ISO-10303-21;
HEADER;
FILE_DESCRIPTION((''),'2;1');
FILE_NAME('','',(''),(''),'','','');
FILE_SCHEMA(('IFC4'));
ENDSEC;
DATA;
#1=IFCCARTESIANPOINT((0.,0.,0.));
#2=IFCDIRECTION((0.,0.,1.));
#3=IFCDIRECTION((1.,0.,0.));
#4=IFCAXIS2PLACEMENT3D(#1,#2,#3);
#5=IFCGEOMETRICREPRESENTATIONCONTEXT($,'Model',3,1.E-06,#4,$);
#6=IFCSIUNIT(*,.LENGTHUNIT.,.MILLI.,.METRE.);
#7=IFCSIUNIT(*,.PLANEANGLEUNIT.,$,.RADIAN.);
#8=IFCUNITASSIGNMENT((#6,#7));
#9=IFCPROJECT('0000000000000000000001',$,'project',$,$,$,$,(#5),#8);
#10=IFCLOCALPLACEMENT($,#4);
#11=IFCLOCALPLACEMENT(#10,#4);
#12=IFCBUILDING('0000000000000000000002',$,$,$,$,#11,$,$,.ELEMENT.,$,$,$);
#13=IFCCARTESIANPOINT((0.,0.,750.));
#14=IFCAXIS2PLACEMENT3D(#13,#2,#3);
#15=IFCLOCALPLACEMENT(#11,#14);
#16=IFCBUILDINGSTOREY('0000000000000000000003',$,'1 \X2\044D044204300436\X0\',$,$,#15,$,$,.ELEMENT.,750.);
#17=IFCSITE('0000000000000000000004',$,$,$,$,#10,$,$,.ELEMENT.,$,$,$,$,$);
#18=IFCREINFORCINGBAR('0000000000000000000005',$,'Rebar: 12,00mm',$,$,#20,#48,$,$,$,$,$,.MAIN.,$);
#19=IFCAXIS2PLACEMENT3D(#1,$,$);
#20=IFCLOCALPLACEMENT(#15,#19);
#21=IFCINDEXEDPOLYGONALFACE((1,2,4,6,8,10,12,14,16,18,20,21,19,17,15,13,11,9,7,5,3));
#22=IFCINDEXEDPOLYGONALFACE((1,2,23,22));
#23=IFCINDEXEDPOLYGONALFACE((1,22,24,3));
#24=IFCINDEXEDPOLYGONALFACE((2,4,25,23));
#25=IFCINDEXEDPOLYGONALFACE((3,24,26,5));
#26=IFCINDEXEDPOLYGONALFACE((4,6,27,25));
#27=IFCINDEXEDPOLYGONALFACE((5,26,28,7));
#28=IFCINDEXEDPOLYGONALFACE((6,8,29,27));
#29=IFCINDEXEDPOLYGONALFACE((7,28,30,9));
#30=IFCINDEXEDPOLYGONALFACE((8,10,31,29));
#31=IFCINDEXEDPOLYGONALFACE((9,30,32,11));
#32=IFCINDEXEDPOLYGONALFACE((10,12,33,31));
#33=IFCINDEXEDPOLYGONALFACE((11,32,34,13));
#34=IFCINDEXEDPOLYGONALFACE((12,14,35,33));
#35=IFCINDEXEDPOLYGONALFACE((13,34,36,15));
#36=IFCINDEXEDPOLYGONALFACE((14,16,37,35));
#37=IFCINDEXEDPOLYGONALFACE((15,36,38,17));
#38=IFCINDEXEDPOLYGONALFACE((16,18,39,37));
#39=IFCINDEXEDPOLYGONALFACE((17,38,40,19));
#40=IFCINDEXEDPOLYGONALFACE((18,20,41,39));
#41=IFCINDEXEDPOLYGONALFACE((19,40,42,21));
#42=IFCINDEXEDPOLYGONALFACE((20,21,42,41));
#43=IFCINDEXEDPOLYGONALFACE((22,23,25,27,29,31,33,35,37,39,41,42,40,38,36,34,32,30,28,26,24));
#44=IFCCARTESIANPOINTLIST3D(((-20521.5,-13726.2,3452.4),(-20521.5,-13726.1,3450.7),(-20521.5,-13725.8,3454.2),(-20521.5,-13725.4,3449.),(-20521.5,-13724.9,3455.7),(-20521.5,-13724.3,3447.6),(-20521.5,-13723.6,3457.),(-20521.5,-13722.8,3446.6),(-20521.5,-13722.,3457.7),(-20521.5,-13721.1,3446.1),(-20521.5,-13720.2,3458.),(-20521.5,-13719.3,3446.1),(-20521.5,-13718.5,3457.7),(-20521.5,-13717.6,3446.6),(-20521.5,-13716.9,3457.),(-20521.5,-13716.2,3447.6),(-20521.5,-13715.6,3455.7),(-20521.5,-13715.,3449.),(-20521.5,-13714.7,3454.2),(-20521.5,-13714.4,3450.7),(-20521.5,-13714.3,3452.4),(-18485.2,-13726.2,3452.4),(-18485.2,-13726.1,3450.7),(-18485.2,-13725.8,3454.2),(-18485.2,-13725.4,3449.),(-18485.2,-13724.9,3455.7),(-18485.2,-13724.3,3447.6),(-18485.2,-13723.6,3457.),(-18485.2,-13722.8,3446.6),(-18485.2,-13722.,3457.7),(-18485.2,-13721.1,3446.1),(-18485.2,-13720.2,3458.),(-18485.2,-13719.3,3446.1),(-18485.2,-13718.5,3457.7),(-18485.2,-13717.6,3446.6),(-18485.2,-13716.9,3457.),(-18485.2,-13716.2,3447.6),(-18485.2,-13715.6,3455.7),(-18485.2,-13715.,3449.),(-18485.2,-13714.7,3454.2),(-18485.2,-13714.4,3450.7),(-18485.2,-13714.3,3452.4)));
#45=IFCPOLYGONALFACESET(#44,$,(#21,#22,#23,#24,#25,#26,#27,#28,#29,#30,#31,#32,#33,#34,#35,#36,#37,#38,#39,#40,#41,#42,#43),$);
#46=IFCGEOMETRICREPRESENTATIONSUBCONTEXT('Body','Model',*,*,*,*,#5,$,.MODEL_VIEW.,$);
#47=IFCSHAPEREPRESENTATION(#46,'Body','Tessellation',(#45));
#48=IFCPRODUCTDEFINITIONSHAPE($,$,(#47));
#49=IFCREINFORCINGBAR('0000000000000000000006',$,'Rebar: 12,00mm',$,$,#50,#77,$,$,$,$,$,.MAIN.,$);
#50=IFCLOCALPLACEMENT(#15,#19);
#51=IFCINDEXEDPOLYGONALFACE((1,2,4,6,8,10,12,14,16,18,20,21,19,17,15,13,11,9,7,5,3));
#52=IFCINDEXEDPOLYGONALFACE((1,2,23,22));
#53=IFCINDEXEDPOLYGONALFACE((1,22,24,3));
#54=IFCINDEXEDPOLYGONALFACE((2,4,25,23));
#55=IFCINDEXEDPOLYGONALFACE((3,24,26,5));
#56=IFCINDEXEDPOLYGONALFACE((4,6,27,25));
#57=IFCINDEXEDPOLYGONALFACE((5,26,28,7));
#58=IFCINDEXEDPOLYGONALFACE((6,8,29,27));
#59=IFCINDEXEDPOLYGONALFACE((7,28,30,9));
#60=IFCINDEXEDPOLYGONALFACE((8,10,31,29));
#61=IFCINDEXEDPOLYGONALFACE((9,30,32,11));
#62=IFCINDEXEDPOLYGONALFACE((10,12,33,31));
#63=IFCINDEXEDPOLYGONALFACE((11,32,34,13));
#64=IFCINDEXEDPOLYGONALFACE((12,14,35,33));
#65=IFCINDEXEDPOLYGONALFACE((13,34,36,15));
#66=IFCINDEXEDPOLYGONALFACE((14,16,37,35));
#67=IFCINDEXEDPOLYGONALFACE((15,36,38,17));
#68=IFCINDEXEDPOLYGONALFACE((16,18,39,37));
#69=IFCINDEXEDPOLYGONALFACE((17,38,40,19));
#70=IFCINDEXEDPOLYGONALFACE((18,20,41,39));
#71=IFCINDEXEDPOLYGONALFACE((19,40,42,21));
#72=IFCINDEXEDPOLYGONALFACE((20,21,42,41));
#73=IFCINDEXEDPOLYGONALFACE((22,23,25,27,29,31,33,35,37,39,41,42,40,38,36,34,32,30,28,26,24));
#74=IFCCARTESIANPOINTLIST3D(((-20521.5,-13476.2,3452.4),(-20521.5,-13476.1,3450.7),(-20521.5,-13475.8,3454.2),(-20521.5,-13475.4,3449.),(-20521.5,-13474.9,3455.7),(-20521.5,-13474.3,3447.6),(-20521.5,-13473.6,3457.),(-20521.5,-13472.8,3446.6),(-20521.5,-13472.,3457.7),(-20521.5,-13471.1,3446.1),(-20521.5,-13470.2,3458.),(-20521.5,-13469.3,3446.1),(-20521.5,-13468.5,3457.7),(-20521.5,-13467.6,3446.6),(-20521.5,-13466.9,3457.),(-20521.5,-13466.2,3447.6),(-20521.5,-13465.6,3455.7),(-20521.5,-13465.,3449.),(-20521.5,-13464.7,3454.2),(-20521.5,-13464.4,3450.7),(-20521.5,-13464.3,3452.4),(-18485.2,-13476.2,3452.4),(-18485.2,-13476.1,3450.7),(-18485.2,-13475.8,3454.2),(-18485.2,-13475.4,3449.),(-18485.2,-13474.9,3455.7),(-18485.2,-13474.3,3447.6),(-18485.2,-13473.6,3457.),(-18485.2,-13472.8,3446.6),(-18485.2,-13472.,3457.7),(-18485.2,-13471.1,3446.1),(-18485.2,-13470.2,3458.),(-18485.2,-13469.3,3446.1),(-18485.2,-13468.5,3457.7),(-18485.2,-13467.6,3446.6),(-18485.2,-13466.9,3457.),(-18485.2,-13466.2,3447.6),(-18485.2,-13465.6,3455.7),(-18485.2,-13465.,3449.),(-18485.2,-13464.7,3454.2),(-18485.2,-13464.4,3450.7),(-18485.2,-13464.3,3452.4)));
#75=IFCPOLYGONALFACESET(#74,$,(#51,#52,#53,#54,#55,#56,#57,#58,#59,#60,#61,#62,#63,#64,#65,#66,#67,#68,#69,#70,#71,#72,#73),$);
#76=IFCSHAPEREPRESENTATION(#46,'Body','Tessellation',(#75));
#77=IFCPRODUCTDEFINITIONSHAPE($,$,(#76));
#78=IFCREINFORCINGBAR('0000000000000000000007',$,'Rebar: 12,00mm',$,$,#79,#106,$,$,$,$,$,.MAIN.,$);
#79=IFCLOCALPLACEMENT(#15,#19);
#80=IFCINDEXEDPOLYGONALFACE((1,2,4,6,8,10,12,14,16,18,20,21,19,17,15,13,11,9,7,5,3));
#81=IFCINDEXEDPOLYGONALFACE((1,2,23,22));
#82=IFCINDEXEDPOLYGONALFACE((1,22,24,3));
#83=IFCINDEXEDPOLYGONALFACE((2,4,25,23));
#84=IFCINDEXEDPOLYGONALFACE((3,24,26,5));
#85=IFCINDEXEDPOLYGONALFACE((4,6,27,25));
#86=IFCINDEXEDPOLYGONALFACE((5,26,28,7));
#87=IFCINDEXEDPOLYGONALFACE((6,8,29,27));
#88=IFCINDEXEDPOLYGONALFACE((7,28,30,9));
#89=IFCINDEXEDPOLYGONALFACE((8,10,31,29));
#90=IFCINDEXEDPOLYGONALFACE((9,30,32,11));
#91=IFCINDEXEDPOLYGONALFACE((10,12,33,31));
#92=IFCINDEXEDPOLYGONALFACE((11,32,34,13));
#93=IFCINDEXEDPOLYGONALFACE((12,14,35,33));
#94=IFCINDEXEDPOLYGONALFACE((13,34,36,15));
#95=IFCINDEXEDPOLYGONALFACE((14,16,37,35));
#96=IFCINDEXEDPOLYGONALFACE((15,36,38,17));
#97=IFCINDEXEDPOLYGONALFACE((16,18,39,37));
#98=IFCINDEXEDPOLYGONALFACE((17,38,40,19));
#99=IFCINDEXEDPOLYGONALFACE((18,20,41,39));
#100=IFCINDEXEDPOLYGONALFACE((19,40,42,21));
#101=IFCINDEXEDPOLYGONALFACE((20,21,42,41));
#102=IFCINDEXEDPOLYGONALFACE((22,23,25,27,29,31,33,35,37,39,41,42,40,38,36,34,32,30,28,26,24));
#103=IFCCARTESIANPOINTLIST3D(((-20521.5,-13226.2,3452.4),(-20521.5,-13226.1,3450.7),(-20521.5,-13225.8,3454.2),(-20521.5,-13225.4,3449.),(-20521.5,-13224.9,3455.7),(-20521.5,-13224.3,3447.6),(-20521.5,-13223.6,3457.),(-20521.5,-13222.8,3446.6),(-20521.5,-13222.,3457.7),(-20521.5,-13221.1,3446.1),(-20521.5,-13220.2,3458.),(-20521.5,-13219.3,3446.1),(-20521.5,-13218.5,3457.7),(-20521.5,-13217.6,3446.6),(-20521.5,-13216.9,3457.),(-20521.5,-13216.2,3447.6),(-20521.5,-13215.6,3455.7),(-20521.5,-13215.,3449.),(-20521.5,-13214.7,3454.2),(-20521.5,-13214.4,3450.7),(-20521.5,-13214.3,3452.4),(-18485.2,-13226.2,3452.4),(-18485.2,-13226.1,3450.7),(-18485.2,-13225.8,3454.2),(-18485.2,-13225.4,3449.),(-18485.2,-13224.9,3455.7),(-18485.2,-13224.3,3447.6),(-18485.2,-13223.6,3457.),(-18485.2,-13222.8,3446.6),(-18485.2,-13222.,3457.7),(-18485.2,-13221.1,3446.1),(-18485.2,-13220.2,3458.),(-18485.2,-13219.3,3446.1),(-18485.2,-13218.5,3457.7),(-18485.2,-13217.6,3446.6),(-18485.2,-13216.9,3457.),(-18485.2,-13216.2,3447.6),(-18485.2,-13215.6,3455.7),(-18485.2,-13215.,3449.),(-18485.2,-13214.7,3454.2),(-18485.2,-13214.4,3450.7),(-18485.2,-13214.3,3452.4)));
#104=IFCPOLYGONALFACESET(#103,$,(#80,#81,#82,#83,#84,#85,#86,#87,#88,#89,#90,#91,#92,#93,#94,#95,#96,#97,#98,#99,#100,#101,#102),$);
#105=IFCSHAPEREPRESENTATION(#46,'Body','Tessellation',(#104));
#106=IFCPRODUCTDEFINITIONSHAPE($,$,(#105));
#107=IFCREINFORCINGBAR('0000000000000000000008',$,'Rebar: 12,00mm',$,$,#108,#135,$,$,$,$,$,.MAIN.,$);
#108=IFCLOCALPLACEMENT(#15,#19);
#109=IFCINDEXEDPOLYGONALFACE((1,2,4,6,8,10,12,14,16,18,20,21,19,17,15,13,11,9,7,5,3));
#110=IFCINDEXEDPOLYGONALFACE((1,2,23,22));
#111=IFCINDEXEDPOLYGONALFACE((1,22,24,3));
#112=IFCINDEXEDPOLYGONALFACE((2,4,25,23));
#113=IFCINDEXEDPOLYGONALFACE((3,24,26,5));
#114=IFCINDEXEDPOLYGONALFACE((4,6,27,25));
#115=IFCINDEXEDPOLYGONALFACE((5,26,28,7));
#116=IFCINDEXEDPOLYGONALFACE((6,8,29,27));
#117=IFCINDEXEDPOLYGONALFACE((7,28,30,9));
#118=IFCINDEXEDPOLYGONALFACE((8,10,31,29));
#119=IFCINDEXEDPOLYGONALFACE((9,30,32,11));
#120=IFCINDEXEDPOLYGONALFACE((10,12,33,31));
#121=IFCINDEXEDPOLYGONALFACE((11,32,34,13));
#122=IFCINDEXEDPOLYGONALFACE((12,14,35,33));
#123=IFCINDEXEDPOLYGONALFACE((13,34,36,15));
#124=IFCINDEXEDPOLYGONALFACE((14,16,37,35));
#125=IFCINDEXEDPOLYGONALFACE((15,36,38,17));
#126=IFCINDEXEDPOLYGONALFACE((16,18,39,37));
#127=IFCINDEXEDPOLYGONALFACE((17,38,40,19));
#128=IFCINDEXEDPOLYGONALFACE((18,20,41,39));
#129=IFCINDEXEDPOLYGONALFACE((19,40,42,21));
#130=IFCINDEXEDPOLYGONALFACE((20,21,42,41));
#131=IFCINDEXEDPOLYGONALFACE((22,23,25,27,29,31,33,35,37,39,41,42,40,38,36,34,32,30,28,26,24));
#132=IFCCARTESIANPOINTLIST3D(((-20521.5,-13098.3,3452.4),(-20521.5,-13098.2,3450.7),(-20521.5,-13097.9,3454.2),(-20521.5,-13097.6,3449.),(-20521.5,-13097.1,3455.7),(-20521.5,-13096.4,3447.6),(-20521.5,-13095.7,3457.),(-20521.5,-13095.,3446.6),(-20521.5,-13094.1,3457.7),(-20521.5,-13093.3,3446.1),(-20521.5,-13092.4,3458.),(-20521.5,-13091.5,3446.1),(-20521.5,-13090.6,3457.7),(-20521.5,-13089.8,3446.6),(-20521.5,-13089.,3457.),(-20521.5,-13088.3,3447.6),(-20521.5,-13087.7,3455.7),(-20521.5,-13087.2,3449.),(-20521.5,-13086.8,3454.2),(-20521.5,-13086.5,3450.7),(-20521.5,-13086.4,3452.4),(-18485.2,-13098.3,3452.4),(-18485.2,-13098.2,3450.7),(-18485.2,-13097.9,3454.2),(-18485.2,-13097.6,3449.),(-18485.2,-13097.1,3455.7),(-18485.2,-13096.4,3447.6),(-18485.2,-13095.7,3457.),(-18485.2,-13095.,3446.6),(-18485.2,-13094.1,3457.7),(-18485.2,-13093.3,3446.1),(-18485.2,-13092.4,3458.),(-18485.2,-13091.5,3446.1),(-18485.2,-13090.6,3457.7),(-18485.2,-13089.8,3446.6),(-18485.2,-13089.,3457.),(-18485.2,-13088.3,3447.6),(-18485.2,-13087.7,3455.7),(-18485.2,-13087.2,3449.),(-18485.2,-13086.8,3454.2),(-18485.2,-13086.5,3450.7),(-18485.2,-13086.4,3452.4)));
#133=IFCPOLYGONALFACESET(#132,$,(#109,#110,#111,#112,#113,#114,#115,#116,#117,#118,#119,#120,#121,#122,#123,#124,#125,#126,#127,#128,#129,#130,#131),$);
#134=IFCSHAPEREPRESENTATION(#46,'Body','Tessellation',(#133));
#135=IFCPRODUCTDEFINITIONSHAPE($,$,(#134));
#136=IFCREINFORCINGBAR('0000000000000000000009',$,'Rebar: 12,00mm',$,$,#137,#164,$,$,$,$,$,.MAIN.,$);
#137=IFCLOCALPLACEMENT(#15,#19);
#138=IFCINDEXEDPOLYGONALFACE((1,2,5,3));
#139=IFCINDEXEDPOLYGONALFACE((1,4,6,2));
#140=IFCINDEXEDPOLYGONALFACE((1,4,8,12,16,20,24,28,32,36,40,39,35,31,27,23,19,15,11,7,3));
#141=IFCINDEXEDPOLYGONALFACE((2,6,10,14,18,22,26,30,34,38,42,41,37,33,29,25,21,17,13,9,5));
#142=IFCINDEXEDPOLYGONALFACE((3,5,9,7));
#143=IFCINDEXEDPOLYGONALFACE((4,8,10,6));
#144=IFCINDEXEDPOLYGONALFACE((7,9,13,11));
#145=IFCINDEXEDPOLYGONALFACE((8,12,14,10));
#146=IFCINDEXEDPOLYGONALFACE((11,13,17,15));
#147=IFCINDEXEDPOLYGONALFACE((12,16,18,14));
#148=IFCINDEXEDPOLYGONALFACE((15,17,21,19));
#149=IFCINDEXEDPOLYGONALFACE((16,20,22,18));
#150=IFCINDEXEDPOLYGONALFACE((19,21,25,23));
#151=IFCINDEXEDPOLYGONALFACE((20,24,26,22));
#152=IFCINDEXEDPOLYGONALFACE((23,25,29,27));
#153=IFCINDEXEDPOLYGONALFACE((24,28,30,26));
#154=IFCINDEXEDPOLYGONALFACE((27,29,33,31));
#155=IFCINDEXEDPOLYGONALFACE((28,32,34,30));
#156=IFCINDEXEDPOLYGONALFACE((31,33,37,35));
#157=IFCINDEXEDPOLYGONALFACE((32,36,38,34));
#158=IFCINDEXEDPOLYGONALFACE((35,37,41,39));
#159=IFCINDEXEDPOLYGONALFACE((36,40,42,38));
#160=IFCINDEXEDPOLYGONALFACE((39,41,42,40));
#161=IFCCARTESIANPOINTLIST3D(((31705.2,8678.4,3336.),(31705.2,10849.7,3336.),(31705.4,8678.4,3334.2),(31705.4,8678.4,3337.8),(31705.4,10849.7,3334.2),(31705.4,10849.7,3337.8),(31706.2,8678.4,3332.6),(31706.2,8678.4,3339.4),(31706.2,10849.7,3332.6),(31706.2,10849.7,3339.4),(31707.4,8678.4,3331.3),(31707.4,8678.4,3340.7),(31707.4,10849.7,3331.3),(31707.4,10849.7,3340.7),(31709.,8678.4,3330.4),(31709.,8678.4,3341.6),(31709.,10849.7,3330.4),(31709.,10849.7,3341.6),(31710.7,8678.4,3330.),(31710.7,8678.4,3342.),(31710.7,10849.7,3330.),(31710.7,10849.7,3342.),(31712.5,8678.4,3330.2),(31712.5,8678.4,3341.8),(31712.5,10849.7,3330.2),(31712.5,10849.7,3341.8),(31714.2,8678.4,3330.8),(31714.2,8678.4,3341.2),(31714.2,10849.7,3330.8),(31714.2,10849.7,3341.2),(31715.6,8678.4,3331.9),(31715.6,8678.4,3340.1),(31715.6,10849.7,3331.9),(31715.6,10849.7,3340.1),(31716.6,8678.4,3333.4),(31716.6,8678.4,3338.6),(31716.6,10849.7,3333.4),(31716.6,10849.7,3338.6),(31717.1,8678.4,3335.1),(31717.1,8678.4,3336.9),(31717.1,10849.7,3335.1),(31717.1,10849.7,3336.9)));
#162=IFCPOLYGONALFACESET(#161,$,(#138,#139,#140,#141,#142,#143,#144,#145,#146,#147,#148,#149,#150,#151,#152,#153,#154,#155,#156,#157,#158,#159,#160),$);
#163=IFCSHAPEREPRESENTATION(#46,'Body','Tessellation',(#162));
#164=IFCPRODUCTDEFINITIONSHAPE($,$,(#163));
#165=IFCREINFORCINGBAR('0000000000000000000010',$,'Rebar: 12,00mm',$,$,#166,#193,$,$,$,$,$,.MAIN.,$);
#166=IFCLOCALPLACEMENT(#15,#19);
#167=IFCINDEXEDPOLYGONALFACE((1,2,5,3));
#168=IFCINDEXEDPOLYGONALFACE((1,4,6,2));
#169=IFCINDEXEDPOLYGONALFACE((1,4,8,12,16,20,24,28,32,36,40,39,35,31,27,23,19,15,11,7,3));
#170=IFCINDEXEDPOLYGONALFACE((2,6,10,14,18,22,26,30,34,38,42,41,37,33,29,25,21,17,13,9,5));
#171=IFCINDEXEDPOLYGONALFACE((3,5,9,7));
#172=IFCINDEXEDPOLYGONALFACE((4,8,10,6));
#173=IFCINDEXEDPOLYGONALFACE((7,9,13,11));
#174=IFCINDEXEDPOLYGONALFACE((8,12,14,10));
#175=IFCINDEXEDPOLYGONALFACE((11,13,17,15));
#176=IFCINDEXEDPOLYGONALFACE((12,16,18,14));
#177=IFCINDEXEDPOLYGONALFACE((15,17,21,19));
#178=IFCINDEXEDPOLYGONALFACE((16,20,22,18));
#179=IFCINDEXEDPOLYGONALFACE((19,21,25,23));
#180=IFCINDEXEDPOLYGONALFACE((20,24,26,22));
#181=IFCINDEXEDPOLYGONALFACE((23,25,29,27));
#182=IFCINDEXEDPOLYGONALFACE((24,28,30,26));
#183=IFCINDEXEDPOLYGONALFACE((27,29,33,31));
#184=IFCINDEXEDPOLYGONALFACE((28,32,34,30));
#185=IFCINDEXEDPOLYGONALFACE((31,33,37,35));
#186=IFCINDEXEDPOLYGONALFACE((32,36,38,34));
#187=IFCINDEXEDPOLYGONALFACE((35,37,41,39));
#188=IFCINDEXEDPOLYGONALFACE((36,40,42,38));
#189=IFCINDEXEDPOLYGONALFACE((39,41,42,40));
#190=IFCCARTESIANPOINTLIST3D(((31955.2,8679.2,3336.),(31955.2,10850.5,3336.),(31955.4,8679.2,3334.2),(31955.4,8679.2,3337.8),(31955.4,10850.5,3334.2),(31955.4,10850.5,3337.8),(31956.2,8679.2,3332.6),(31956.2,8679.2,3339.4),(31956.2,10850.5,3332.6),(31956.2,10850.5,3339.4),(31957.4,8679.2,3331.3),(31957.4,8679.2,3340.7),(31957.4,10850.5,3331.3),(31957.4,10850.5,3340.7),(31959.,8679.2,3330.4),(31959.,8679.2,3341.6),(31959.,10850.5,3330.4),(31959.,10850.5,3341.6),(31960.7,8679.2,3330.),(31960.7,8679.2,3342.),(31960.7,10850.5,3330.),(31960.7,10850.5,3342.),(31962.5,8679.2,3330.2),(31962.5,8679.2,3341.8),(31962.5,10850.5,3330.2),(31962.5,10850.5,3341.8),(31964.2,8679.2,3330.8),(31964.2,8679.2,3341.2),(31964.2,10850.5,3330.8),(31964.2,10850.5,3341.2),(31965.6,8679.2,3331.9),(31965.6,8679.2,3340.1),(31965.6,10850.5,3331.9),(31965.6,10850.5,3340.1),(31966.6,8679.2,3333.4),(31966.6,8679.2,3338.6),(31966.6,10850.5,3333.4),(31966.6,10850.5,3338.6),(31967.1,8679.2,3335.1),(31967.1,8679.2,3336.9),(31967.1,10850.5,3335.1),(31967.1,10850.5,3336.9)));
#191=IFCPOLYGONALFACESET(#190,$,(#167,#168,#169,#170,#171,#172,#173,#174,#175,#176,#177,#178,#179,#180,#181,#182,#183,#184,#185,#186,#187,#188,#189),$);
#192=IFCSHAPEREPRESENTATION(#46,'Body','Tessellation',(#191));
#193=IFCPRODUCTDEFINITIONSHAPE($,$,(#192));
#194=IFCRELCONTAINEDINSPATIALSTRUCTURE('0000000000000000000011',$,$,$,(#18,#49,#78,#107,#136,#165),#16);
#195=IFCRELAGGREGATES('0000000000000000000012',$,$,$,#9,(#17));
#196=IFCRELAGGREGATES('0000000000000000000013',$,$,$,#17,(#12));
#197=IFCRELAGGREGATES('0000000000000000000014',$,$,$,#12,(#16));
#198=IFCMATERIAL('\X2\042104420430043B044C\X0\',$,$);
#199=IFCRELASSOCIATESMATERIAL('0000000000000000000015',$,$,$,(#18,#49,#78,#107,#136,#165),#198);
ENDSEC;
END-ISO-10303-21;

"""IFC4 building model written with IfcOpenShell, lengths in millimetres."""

from ifc_helpers import new_model, entity, si_unit, frame, origin_with_axes, place, context, subcontext, project, spatial, source, transform, mapped, material, element, save


model = new_model("IFC4")

# Units and contexts
model_context = context("Model", 3, precision=1e-06, world=origin_with_axes())
body_context = subcontext(model_context, "Body", "Model", "MODEL_VIEW")
ifc_project = project(units=[si_unit("LENGTHUNIT", "METRE", prefix="MILLI"), si_unit("PLANEANGLEUNIT", "RADIAN")], contexts=[model_context])

# Site, building, storey
site_placement = place(None, origin_with_axes())
site = spatial("IfcSite", under=ifc_project, at=site_placement, CompositionType="ELEMENT")
building_placement = place(site_placement, origin_with_axes())
building = spatial("IfcBuilding", under=site, at=building_placement, CompositionType="ELEMENT")
storey_placement = place(building_placement, frame((0.0, 0.0, 750.0), z_axis=(0.0, 0.0, 1.0), x_axis=(1.0, 0.0, 0.0)))
storey = spatial("IfcBuildingStorey", under=building, at=storey_placement, Name="1 этаж", CompositionType="ELEMENT", Elevation=750.0)

# Reinforcing bars
ifc_material = material(Name="Сталь")
shared_shape_1 = source(origin_with_axes(), body_context, "Body", "AdvancedSweptSolid", [
    entity("IfcSweptDiskSolid", entity("IfcIndexedPolyCurve", entity("IfcCartesianPointList3D", [[0.0, 0.0, 0.0], [2036.2, 0.0, 0.0]]), [entity("IfcLineIndex", [1, 2])]), 6.0),
])
reinforcing_bar_1_placement = place(storey_placement, origin_with_axes())
element("IfcReinforcingBar", 1, at=reinforcing_bar_1_placement, inside=storey, material=ifc_material, Name="Rebar: 12,00mm", PredefinedType="MAIN", context=body_context, shape_type="MappedRepresentation", body=[
    mapped(shared_shape_1, transform((-20521.5, -13720.2, 3452.0), x_axis=(1.0, 0.0, 0.0), y_axis=(0.0, 1.0, 0.0), z_axis=(0.0, 0.0, 1.0), scale=1.0)),
])
reinforcing_bar_2_placement = place(storey_placement, origin_with_axes())
element("IfcReinforcingBar", 2, at=reinforcing_bar_2_placement, inside=storey, material=ifc_material, Name="Rebar: 12,00mm", PredefinedType="MAIN", context=body_context, shape_type="MappedRepresentation", body=[
    mapped(shared_shape_1, transform((-20521.5, -13470.2, 3452.0), x_axis=(1.0, 0.0, 0.0), y_axis=(0.0, 1.0, 0.0), z_axis=(0.0, 0.0, 1.0), scale=1.0)),
])
reinforcing_bar_3_placement = place(storey_placement, origin_with_axes())
element("IfcReinforcingBar", 3, at=reinforcing_bar_3_placement, inside=storey, material=ifc_material, Name="Rebar: 12,00mm", PredefinedType="MAIN", context=body_context, shape_type="MappedRepresentation", body=[
    mapped(shared_shape_1, transform((-20521.5, -13220.2, 3452.0), x_axis=(1.0, 0.0, 0.0), y_axis=(0.0, 1.0, 0.0), z_axis=(0.0, 0.0, 1.0), scale=1.0)),
])
reinforcing_bar_4_placement = place(storey_placement, origin_with_axes())
element("IfcReinforcingBar", 4, at=reinforcing_bar_4_placement, inside=storey, material=ifc_material, Name="Rebar: 12,00mm", PredefinedType="MAIN", context=body_context, shape_type="MappedRepresentation", body=[
    mapped(shared_shape_1, transform((-20521.5, -13092.4, 3452.0), x_axis=(1.0, 0.0, 0.0), y_axis=(0.0, 1.0, 0.0), z_axis=(0.0, 0.0, 1.0), scale=1.0)),
])
shared_shape_2 = source(origin_with_axes(), body_context, "Body", "AdvancedSweptSolid", [
    entity("IfcSweptDiskSolid", entity("IfcIndexedPolyCurve", entity("IfcCartesianPointList3D", [[0.0, 0.0, 0.0], [2171.3, 0.0, 0.0]]), [entity("IfcLineIndex", [1, 2])]), 6.0),
])
reinforcing_bar_5_placement = place(storey_placement, origin_with_axes())
element("IfcReinforcingBar", 5, at=reinforcing_bar_5_placement, inside=storey, material=ifc_material, Name="Rebar: 12,00mm", PredefinedType="MAIN", context=body_context, shape_type="MappedRepresentation", body=[
    mapped(shared_shape_2, transform((31711.2, 8678.4, 3336.0), x_axis=(0.0, 1.0, 0.0), y_axis=(-1.0, 0.0, 0.0), z_axis=(0.0, 0.0, 1.0), scale=1.0)),
])
reinforcing_bar_6_placement = place(storey_placement, origin_with_axes())
element("IfcReinforcingBar", 6, at=reinforcing_bar_6_placement, inside=storey, material=ifc_material, Name="Rebar: 12,00mm", PredefinedType="MAIN", context=body_context, shape_type="MappedRepresentation", body=[
    mapped(shared_shape_2, transform((31961.2, 8679.2, 3336.0), x_axis=(0.0, 1.0, 0.0), y_axis=(-1.0, 0.0, 0.0), z_axis=(0.0, 0.0, 1.0), scale=1.0)),
])

save(model, "model.ifc")
